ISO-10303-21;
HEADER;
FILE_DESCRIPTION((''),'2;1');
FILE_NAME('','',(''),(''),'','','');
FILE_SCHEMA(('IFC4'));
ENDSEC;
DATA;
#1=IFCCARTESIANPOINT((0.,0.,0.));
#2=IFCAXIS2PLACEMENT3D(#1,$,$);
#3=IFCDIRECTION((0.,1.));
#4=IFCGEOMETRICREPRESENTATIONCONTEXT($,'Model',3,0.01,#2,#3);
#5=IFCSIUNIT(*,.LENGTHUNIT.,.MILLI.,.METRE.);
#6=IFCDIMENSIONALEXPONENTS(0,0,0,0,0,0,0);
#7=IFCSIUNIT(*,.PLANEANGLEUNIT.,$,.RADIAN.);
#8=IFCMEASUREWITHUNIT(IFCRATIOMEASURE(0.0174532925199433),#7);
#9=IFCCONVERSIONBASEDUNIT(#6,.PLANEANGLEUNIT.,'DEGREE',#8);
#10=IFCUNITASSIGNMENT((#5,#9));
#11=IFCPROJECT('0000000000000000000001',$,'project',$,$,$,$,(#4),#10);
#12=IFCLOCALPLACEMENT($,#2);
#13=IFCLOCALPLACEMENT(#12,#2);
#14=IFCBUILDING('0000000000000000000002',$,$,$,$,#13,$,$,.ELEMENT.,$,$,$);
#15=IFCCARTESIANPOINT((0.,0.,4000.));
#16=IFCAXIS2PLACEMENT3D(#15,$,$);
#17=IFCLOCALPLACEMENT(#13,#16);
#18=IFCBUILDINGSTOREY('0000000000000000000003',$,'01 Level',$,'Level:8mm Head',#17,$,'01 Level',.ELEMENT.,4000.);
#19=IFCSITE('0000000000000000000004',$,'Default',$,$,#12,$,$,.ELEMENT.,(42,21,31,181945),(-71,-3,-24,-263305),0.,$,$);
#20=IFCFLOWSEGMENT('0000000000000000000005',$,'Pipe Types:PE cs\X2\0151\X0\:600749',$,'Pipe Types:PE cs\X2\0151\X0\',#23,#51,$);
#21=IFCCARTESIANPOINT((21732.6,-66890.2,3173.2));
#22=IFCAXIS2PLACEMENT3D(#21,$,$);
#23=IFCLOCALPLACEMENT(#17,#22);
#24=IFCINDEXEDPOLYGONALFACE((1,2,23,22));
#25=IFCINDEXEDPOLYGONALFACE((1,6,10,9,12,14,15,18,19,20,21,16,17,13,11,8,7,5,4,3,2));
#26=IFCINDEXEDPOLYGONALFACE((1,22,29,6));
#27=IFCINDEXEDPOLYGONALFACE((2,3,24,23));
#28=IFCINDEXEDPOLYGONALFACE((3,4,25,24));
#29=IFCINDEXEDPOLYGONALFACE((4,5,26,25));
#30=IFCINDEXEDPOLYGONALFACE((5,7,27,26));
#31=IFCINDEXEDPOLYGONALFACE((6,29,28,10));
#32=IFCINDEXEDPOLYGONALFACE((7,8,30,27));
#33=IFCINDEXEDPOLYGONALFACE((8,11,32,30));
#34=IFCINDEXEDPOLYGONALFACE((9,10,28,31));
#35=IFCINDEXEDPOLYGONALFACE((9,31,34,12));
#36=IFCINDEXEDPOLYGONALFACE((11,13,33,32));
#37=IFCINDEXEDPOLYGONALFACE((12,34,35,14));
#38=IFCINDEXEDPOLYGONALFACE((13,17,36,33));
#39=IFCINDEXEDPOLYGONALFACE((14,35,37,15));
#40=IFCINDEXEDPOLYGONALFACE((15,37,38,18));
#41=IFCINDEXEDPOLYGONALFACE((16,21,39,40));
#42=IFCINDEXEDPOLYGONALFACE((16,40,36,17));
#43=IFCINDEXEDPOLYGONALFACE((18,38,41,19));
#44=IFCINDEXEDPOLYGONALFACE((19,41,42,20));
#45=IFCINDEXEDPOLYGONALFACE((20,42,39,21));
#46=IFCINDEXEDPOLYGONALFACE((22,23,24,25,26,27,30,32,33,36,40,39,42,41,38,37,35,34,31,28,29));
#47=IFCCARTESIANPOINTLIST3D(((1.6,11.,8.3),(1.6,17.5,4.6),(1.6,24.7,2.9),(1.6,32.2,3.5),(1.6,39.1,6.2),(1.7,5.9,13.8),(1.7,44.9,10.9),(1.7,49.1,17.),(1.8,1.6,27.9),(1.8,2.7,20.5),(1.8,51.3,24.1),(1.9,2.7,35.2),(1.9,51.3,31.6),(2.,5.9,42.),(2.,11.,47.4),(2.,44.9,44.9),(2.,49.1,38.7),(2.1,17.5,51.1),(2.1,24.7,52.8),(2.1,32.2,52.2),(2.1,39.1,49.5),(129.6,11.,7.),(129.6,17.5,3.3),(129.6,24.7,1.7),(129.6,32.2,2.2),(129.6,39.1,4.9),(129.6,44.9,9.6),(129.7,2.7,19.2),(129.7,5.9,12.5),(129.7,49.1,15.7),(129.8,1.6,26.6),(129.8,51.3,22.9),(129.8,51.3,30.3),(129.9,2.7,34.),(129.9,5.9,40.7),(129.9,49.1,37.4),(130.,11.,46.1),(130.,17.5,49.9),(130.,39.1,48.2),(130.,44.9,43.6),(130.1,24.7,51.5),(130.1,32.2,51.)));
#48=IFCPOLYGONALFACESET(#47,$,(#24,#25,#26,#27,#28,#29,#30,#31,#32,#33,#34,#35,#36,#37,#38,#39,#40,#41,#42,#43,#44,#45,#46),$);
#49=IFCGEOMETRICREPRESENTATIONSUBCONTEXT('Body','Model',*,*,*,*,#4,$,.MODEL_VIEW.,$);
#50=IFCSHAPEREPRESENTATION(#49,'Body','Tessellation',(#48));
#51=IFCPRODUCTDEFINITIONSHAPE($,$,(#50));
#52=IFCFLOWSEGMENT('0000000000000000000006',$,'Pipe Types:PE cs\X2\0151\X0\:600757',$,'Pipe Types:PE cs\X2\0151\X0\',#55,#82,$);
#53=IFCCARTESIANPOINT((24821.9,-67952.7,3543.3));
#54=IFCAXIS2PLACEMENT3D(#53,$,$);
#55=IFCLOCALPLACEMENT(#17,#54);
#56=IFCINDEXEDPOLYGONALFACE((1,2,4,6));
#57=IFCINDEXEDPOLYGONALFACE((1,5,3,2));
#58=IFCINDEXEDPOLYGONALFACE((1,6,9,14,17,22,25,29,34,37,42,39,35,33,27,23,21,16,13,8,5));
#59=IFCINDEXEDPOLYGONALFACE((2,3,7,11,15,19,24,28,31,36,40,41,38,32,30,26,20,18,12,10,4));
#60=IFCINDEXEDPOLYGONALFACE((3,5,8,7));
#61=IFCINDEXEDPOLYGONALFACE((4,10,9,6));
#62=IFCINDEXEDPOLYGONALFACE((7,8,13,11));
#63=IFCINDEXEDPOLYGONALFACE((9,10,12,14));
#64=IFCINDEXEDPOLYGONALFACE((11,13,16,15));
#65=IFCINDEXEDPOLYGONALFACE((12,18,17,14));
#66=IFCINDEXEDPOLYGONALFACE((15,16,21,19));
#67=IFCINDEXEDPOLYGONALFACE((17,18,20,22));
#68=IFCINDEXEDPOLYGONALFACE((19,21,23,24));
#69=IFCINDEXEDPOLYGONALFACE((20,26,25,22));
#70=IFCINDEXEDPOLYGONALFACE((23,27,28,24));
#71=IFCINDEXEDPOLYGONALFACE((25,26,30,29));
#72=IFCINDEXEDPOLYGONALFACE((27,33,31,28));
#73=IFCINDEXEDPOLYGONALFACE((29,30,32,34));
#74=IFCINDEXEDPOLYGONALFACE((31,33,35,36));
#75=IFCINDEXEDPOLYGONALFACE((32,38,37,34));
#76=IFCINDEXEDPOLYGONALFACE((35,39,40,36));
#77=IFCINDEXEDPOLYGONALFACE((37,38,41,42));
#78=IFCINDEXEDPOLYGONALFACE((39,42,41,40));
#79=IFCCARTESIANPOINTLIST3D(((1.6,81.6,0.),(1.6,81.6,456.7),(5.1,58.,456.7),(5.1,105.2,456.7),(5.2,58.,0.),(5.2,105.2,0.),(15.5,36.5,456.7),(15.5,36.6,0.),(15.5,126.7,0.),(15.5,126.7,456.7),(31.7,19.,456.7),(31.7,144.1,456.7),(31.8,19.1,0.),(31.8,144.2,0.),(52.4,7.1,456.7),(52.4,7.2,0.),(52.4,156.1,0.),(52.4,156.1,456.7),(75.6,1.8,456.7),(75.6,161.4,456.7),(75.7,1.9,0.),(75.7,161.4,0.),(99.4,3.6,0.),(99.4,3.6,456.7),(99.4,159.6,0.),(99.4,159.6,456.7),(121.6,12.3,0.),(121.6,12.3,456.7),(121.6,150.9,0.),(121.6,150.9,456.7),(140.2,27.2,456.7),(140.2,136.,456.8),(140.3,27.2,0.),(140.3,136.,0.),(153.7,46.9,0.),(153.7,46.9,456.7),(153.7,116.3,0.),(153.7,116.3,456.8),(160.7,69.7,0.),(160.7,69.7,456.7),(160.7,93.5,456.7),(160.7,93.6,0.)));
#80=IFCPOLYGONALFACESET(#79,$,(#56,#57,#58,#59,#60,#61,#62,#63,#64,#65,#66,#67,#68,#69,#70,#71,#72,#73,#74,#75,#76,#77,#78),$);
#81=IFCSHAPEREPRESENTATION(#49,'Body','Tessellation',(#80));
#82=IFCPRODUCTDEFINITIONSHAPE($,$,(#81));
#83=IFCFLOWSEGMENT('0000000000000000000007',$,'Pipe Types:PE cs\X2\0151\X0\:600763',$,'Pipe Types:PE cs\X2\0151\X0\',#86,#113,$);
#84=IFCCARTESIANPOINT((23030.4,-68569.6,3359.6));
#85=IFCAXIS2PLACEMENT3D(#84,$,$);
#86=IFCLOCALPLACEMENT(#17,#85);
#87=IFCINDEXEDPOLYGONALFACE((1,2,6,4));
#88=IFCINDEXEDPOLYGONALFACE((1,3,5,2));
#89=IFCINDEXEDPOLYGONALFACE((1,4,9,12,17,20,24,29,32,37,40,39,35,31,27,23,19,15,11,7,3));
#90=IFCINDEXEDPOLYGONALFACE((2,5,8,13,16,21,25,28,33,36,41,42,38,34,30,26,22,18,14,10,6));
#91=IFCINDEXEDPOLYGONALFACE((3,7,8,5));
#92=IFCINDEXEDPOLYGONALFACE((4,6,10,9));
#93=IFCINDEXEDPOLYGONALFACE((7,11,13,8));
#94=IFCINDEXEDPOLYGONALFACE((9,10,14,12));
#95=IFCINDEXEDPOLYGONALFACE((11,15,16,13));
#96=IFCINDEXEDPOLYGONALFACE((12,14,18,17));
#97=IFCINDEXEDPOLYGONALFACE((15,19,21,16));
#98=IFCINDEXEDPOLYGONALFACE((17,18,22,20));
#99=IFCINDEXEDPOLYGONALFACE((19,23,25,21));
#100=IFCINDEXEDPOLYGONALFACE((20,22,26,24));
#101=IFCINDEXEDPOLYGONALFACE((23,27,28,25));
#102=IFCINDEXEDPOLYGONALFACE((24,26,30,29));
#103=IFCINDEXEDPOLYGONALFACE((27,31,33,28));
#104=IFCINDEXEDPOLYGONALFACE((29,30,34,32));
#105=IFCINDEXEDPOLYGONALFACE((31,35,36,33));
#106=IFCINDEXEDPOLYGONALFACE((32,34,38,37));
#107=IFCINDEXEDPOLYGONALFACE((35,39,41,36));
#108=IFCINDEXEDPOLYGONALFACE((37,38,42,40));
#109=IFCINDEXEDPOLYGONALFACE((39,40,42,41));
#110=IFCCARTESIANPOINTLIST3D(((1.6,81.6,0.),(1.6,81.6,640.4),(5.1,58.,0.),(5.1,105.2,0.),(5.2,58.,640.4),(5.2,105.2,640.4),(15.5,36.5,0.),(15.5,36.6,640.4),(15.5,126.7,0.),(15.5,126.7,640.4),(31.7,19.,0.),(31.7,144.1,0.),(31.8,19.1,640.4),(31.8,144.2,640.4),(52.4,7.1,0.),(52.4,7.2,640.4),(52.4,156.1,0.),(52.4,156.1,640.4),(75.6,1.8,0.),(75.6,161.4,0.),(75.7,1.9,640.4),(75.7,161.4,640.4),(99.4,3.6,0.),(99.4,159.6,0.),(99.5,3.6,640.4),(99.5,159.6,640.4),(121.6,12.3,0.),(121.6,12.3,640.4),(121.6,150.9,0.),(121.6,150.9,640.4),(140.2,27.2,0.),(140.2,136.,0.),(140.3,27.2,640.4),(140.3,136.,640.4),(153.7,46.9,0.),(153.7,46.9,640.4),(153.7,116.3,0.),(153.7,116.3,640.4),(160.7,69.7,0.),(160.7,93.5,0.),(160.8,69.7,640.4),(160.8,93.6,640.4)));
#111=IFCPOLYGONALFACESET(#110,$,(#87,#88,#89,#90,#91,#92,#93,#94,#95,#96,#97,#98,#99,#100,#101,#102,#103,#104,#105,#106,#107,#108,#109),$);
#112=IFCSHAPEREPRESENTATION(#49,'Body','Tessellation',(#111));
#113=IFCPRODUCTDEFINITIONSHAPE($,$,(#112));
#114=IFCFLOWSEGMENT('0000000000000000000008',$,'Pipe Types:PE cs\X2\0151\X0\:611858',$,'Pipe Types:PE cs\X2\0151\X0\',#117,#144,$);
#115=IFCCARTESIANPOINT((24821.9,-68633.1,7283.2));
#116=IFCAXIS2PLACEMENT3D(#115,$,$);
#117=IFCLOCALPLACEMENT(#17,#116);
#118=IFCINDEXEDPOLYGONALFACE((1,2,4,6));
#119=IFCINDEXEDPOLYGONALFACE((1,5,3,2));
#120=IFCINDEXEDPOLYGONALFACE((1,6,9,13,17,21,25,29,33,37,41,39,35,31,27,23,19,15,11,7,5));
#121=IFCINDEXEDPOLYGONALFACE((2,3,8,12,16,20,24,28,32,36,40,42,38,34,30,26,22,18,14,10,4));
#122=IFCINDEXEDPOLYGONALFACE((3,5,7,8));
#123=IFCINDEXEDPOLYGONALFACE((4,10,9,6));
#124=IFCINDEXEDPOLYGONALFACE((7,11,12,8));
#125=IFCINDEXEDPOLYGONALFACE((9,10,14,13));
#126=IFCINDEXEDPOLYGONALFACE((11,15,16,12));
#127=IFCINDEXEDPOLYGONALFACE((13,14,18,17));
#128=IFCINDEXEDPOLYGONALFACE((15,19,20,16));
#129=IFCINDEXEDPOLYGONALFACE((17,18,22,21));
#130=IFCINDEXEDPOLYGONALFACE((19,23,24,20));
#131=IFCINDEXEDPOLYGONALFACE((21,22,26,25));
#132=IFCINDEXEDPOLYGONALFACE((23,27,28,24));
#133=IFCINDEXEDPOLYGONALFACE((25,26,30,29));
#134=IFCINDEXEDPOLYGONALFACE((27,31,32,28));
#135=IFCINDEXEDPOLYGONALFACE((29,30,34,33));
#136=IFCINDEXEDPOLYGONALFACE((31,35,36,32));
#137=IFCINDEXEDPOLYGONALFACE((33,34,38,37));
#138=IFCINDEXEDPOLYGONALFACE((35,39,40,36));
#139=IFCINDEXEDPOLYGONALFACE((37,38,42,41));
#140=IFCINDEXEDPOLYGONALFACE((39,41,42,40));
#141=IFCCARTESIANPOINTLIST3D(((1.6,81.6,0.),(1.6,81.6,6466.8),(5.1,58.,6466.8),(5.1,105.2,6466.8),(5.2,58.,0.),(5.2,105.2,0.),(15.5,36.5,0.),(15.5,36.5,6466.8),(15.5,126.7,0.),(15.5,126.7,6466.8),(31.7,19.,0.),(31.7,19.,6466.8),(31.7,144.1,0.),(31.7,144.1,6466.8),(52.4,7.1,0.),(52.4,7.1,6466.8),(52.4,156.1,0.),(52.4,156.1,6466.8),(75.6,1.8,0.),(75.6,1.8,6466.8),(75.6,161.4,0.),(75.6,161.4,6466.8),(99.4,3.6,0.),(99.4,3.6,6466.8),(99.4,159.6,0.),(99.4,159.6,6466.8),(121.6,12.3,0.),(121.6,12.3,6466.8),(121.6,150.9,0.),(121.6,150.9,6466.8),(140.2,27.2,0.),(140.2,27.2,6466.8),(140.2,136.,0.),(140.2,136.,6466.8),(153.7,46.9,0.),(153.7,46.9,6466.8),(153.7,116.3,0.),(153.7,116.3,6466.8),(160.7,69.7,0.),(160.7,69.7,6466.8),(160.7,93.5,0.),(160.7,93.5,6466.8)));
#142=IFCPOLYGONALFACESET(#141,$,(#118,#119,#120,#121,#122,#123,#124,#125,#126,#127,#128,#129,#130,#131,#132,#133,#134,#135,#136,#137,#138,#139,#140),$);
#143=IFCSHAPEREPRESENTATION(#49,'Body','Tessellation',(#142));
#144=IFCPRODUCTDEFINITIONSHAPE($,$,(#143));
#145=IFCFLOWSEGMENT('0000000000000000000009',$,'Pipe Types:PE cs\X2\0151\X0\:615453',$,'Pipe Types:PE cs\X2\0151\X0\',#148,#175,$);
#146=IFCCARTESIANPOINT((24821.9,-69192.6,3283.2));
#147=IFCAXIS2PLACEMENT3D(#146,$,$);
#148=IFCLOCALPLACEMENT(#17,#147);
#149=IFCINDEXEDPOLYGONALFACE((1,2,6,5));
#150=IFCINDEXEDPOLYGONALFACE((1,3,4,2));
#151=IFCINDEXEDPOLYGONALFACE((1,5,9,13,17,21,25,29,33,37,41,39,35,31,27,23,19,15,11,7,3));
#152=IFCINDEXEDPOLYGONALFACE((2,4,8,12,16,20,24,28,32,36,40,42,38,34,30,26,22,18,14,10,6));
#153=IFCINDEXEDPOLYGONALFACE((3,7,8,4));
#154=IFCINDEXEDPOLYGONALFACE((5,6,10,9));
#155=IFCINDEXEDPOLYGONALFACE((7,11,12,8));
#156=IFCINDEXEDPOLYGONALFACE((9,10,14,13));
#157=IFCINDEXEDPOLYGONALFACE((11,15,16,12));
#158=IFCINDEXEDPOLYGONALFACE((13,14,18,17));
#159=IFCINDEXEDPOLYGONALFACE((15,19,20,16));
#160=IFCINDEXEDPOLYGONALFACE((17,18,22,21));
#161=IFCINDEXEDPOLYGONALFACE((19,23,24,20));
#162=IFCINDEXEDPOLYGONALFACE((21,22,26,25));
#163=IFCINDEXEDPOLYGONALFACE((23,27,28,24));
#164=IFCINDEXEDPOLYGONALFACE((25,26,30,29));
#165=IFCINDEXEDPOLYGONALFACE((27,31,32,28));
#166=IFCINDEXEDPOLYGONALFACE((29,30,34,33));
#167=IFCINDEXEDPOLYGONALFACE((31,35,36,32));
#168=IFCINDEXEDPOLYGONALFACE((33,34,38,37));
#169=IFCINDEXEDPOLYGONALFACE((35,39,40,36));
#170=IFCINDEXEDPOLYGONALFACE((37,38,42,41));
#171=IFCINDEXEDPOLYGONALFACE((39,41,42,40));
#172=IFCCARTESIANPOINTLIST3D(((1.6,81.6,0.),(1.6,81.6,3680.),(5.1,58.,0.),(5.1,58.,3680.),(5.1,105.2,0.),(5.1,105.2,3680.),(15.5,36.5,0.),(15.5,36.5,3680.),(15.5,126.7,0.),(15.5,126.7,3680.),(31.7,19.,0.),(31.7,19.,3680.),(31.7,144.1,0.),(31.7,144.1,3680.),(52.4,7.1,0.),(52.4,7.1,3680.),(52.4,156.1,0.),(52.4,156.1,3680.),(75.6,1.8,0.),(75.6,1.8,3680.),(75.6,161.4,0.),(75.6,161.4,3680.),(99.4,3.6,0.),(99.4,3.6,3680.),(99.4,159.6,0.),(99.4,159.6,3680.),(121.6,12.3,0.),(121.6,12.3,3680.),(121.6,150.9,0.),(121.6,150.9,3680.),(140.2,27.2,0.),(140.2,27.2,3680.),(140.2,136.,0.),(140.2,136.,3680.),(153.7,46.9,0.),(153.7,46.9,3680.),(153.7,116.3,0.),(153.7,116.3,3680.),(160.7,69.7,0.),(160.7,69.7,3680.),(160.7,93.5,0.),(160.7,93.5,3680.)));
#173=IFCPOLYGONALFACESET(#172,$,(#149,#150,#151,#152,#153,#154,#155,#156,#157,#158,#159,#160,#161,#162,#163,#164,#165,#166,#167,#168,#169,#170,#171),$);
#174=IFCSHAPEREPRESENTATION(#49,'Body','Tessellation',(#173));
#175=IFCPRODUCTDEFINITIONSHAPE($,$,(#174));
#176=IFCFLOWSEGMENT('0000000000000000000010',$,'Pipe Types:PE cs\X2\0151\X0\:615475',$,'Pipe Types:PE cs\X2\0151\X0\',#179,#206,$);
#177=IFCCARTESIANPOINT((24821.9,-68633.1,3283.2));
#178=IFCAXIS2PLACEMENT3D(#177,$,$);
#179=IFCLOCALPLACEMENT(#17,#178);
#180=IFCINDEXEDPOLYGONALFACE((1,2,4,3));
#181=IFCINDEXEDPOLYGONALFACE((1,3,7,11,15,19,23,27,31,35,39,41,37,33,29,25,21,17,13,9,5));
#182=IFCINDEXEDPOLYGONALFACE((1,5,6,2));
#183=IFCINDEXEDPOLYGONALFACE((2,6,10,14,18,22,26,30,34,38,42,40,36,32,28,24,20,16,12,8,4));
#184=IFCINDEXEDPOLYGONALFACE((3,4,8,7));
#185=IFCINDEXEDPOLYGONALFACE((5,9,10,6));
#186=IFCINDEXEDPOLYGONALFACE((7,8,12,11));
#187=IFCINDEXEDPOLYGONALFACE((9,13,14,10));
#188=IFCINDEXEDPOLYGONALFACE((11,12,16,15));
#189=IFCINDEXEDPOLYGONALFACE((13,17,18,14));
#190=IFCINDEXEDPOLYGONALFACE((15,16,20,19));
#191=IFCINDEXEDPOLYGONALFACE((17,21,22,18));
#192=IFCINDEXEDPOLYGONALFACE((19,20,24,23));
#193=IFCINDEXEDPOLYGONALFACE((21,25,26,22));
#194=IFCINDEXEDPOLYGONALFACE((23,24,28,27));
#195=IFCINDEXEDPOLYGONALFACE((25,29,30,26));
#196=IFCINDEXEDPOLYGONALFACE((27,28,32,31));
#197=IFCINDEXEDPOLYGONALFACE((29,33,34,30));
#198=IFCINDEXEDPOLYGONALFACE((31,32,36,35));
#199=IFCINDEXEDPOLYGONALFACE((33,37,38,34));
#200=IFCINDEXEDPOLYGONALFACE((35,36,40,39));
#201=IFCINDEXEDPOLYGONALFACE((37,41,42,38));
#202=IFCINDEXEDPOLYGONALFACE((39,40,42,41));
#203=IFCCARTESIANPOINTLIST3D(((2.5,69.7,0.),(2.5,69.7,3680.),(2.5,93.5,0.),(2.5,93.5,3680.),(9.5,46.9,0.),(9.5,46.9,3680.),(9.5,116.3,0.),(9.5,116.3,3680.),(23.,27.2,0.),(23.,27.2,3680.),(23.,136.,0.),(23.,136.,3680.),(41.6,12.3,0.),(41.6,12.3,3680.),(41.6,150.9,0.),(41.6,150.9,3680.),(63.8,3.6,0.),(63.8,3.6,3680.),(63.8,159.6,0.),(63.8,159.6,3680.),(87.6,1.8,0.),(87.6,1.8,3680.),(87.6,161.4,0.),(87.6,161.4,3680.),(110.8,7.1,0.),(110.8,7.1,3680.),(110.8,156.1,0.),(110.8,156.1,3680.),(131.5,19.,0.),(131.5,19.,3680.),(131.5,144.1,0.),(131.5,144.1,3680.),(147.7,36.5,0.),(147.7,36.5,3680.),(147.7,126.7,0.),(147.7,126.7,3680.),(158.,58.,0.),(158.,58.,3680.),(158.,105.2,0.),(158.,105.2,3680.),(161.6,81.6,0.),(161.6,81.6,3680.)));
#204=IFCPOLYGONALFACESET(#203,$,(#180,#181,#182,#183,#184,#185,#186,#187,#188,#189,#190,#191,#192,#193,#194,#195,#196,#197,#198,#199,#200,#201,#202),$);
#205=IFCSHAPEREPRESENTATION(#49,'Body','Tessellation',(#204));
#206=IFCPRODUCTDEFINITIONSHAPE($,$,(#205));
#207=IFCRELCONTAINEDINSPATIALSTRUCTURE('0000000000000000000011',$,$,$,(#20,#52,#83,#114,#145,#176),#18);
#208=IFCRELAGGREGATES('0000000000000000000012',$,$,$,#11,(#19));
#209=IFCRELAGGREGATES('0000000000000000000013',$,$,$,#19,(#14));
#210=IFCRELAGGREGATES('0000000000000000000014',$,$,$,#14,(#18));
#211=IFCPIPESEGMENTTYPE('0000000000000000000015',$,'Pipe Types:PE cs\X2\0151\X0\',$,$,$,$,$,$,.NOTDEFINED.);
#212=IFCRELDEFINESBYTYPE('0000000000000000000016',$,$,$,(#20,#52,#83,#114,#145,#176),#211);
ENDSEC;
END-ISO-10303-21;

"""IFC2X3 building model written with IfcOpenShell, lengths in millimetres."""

from ifc_helpers import new_model, entity, si_unit, converted_unit, direction, frame, frame_2d, origin, origin_2d_with_axis, place, context, subcontext, project, spatial, circle, extrude, type_object, element, save


model = new_model("IFC2X3")

# Units and contexts
model_context = context("Model", 3, precision=0.01, world=origin(), true_north=direction((0.0, 1.0)))
body_context = subcontext(model_context, "Body", "Model", "MODEL_VIEW")
ifc_project = project(units=[si_unit("LENGTHUNIT", "METRE", prefix="MILLI"), converted_unit("PLANEANGLEUNIT", "DEGREE", entity("IfcRatioMeasure", 0.0174532925199433), si_unit("PLANEANGLEUNIT", "RADIAN"), dimensions=[0, 0, 0, 0, 0, 0, 0])], contexts=[model_context])

# Site, building, storey
site_placement = place(None, origin())
site = spatial("IfcSite", under=ifc_project, at=site_placement, Name="Default", CompositionType="ELEMENT", RefLatitude=(42, 21, 31, 181945), RefLongitude=(-71, -3, -24, -263305), RefElevation=0.0)
building_placement = place(site_placement, origin())
building = spatial("IfcBuilding", under=site, at=building_placement, CompositionType="ELEMENT")
storey_placement = place(building_placement, frame((0.0, 0.0, 4000.0)))
storey = spatial("IfcBuildingStorey", under=building, at=storey_placement, Name="01 Level", ObjectType="Level:8mm Head", LongName="01 Level", CompositionType="ELEMENT", Elevation=4000.0)

# Flow segments
pipe_segment_type = type_object("IfcPipeSegmentType", Name="Pipe Types:PE cső", PredefinedType="NOTDEFINED")
flow_segment_1_placement = place(storey_placement, frame((21732.6, -66890.2, 3173.2)))
element("IfcFlowSegment", 1, at=flow_segment_1_placement, inside=storey, type_object=pipe_segment_type, Name="Pipe Types:PE cső:600749", ObjectType="Pipe Types:PE cső", context=body_context, shape_type="SweptSolid", body=[
    extrude(circle(Radius=25.0, at=origin_2d_with_axis()), frame((129.8, 26.6, 26.6), z_axis=(-0.99995, 0.0, 0.01), x_axis=(0.0, -1.0, 0.0)), (0.0, 0.0, 1.0), 128.0),
])
flow_segment_2_placement = place(storey_placement, frame((24821.9, -67952.7, 3543.3)))
element("IfcFlowSegment", 2, at=flow_segment_2_placement, inside=storey, type_object=pipe_segment_type, Name="Pipe Types:PE cső:600757", ObjectType="Pipe Types:PE cső", context=body_context, shape_type="SweptSolid", body=[
    extrude(circle(Radius=80.0, at=frame_2d((0.0, 0.0), x_axis=(1.0, 0.0))), frame((81.6, 81.6, 0.0), z_axis=(-0.000102, -0.00007, 1.0), x_axis=(-1.0, 0.0, -0.000102)), (0.0, 0.0, 1.0), 456.7),
])
flow_segment_3_placement = place(storey_placement, frame((23030.4, -68569.6, 3359.6)))
element("IfcFlowSegment", 3, at=flow_segment_3_placement, inside=storey, type_object=pipe_segment_type, Name="Pipe Types:PE cső:600763", ObjectType="Pipe Types:PE cső", context=body_context, shape_type="SweptSolid", body=[
    extrude(circle(Radius=80.0, at=frame_2d((0.0, 0.0), x_axis=(1.0, 0.0))), frame((81.6, 81.6, 0.0), z_axis=(0.000084, 0.000051, 1.0), x_axis=(-1.0, 0.0, 0.000084)), (0.0, 0.0, 1.0), 640.4),
])
flow_segment_4_placement = place(storey_placement, frame((24821.9, -68633.1, 7283.2)))
element("IfcFlowSegment", 4, at=flow_segment_4_placement, inside=storey, type_object=pipe_segment_type, Name="Pipe Types:PE cső:611858", ObjectType="Pipe Types:PE cső", context=body_context, shape_type="SweptSolid", body=[
    extrude(circle(Radius=80.0, at=origin_2d_with_axis()), frame((81.6, 81.6, 0.0), z_axis=(-0.000001, 0.0, 1.0), x_axis=(-1.0, 0.0, -0.000001)), (0.0, 0.0, 1.0), 6466.8),
])
flow_segment_5_placement = place(storey_placement, frame((24821.9, -69192.6, 3283.2)))
element("IfcFlowSegment", 5, at=flow_segment_5_placement, inside=storey, type_object=pipe_segment_type, Name="Pipe Types:PE cső:615453", ObjectType="Pipe Types:PE cső", context=body_context, shape_type="SweptSolid", body=[
    extrude(circle(Radius=80.0, at=origin_2d_with_axis()), frame((81.6, 81.6, 0.0), z_axis=(0.0, 0.0, 1.0), x_axis=(-1.0, 0.0, 0.0)), (0.0, 0.0, 1.0), 3680.0),
])
flow_segment_6_placement = place(storey_placement, frame((24821.9, -68633.1, 3283.2)))
element("IfcFlowSegment", 6, at=flow_segment_6_placement, inside=storey, type_object=pipe_segment_type, Name="Pipe Types:PE cső:615475", ObjectType="Pipe Types:PE cső", context=body_context, shape_type="SweptSolid", body=[
    extrude(circle(Radius=80.0, at=origin_2d_with_axis()), frame((81.6, 81.6, 0.0)), (0.0, 0.0, 1.0), 3680.0),
])

save(model, "model.ifc")
